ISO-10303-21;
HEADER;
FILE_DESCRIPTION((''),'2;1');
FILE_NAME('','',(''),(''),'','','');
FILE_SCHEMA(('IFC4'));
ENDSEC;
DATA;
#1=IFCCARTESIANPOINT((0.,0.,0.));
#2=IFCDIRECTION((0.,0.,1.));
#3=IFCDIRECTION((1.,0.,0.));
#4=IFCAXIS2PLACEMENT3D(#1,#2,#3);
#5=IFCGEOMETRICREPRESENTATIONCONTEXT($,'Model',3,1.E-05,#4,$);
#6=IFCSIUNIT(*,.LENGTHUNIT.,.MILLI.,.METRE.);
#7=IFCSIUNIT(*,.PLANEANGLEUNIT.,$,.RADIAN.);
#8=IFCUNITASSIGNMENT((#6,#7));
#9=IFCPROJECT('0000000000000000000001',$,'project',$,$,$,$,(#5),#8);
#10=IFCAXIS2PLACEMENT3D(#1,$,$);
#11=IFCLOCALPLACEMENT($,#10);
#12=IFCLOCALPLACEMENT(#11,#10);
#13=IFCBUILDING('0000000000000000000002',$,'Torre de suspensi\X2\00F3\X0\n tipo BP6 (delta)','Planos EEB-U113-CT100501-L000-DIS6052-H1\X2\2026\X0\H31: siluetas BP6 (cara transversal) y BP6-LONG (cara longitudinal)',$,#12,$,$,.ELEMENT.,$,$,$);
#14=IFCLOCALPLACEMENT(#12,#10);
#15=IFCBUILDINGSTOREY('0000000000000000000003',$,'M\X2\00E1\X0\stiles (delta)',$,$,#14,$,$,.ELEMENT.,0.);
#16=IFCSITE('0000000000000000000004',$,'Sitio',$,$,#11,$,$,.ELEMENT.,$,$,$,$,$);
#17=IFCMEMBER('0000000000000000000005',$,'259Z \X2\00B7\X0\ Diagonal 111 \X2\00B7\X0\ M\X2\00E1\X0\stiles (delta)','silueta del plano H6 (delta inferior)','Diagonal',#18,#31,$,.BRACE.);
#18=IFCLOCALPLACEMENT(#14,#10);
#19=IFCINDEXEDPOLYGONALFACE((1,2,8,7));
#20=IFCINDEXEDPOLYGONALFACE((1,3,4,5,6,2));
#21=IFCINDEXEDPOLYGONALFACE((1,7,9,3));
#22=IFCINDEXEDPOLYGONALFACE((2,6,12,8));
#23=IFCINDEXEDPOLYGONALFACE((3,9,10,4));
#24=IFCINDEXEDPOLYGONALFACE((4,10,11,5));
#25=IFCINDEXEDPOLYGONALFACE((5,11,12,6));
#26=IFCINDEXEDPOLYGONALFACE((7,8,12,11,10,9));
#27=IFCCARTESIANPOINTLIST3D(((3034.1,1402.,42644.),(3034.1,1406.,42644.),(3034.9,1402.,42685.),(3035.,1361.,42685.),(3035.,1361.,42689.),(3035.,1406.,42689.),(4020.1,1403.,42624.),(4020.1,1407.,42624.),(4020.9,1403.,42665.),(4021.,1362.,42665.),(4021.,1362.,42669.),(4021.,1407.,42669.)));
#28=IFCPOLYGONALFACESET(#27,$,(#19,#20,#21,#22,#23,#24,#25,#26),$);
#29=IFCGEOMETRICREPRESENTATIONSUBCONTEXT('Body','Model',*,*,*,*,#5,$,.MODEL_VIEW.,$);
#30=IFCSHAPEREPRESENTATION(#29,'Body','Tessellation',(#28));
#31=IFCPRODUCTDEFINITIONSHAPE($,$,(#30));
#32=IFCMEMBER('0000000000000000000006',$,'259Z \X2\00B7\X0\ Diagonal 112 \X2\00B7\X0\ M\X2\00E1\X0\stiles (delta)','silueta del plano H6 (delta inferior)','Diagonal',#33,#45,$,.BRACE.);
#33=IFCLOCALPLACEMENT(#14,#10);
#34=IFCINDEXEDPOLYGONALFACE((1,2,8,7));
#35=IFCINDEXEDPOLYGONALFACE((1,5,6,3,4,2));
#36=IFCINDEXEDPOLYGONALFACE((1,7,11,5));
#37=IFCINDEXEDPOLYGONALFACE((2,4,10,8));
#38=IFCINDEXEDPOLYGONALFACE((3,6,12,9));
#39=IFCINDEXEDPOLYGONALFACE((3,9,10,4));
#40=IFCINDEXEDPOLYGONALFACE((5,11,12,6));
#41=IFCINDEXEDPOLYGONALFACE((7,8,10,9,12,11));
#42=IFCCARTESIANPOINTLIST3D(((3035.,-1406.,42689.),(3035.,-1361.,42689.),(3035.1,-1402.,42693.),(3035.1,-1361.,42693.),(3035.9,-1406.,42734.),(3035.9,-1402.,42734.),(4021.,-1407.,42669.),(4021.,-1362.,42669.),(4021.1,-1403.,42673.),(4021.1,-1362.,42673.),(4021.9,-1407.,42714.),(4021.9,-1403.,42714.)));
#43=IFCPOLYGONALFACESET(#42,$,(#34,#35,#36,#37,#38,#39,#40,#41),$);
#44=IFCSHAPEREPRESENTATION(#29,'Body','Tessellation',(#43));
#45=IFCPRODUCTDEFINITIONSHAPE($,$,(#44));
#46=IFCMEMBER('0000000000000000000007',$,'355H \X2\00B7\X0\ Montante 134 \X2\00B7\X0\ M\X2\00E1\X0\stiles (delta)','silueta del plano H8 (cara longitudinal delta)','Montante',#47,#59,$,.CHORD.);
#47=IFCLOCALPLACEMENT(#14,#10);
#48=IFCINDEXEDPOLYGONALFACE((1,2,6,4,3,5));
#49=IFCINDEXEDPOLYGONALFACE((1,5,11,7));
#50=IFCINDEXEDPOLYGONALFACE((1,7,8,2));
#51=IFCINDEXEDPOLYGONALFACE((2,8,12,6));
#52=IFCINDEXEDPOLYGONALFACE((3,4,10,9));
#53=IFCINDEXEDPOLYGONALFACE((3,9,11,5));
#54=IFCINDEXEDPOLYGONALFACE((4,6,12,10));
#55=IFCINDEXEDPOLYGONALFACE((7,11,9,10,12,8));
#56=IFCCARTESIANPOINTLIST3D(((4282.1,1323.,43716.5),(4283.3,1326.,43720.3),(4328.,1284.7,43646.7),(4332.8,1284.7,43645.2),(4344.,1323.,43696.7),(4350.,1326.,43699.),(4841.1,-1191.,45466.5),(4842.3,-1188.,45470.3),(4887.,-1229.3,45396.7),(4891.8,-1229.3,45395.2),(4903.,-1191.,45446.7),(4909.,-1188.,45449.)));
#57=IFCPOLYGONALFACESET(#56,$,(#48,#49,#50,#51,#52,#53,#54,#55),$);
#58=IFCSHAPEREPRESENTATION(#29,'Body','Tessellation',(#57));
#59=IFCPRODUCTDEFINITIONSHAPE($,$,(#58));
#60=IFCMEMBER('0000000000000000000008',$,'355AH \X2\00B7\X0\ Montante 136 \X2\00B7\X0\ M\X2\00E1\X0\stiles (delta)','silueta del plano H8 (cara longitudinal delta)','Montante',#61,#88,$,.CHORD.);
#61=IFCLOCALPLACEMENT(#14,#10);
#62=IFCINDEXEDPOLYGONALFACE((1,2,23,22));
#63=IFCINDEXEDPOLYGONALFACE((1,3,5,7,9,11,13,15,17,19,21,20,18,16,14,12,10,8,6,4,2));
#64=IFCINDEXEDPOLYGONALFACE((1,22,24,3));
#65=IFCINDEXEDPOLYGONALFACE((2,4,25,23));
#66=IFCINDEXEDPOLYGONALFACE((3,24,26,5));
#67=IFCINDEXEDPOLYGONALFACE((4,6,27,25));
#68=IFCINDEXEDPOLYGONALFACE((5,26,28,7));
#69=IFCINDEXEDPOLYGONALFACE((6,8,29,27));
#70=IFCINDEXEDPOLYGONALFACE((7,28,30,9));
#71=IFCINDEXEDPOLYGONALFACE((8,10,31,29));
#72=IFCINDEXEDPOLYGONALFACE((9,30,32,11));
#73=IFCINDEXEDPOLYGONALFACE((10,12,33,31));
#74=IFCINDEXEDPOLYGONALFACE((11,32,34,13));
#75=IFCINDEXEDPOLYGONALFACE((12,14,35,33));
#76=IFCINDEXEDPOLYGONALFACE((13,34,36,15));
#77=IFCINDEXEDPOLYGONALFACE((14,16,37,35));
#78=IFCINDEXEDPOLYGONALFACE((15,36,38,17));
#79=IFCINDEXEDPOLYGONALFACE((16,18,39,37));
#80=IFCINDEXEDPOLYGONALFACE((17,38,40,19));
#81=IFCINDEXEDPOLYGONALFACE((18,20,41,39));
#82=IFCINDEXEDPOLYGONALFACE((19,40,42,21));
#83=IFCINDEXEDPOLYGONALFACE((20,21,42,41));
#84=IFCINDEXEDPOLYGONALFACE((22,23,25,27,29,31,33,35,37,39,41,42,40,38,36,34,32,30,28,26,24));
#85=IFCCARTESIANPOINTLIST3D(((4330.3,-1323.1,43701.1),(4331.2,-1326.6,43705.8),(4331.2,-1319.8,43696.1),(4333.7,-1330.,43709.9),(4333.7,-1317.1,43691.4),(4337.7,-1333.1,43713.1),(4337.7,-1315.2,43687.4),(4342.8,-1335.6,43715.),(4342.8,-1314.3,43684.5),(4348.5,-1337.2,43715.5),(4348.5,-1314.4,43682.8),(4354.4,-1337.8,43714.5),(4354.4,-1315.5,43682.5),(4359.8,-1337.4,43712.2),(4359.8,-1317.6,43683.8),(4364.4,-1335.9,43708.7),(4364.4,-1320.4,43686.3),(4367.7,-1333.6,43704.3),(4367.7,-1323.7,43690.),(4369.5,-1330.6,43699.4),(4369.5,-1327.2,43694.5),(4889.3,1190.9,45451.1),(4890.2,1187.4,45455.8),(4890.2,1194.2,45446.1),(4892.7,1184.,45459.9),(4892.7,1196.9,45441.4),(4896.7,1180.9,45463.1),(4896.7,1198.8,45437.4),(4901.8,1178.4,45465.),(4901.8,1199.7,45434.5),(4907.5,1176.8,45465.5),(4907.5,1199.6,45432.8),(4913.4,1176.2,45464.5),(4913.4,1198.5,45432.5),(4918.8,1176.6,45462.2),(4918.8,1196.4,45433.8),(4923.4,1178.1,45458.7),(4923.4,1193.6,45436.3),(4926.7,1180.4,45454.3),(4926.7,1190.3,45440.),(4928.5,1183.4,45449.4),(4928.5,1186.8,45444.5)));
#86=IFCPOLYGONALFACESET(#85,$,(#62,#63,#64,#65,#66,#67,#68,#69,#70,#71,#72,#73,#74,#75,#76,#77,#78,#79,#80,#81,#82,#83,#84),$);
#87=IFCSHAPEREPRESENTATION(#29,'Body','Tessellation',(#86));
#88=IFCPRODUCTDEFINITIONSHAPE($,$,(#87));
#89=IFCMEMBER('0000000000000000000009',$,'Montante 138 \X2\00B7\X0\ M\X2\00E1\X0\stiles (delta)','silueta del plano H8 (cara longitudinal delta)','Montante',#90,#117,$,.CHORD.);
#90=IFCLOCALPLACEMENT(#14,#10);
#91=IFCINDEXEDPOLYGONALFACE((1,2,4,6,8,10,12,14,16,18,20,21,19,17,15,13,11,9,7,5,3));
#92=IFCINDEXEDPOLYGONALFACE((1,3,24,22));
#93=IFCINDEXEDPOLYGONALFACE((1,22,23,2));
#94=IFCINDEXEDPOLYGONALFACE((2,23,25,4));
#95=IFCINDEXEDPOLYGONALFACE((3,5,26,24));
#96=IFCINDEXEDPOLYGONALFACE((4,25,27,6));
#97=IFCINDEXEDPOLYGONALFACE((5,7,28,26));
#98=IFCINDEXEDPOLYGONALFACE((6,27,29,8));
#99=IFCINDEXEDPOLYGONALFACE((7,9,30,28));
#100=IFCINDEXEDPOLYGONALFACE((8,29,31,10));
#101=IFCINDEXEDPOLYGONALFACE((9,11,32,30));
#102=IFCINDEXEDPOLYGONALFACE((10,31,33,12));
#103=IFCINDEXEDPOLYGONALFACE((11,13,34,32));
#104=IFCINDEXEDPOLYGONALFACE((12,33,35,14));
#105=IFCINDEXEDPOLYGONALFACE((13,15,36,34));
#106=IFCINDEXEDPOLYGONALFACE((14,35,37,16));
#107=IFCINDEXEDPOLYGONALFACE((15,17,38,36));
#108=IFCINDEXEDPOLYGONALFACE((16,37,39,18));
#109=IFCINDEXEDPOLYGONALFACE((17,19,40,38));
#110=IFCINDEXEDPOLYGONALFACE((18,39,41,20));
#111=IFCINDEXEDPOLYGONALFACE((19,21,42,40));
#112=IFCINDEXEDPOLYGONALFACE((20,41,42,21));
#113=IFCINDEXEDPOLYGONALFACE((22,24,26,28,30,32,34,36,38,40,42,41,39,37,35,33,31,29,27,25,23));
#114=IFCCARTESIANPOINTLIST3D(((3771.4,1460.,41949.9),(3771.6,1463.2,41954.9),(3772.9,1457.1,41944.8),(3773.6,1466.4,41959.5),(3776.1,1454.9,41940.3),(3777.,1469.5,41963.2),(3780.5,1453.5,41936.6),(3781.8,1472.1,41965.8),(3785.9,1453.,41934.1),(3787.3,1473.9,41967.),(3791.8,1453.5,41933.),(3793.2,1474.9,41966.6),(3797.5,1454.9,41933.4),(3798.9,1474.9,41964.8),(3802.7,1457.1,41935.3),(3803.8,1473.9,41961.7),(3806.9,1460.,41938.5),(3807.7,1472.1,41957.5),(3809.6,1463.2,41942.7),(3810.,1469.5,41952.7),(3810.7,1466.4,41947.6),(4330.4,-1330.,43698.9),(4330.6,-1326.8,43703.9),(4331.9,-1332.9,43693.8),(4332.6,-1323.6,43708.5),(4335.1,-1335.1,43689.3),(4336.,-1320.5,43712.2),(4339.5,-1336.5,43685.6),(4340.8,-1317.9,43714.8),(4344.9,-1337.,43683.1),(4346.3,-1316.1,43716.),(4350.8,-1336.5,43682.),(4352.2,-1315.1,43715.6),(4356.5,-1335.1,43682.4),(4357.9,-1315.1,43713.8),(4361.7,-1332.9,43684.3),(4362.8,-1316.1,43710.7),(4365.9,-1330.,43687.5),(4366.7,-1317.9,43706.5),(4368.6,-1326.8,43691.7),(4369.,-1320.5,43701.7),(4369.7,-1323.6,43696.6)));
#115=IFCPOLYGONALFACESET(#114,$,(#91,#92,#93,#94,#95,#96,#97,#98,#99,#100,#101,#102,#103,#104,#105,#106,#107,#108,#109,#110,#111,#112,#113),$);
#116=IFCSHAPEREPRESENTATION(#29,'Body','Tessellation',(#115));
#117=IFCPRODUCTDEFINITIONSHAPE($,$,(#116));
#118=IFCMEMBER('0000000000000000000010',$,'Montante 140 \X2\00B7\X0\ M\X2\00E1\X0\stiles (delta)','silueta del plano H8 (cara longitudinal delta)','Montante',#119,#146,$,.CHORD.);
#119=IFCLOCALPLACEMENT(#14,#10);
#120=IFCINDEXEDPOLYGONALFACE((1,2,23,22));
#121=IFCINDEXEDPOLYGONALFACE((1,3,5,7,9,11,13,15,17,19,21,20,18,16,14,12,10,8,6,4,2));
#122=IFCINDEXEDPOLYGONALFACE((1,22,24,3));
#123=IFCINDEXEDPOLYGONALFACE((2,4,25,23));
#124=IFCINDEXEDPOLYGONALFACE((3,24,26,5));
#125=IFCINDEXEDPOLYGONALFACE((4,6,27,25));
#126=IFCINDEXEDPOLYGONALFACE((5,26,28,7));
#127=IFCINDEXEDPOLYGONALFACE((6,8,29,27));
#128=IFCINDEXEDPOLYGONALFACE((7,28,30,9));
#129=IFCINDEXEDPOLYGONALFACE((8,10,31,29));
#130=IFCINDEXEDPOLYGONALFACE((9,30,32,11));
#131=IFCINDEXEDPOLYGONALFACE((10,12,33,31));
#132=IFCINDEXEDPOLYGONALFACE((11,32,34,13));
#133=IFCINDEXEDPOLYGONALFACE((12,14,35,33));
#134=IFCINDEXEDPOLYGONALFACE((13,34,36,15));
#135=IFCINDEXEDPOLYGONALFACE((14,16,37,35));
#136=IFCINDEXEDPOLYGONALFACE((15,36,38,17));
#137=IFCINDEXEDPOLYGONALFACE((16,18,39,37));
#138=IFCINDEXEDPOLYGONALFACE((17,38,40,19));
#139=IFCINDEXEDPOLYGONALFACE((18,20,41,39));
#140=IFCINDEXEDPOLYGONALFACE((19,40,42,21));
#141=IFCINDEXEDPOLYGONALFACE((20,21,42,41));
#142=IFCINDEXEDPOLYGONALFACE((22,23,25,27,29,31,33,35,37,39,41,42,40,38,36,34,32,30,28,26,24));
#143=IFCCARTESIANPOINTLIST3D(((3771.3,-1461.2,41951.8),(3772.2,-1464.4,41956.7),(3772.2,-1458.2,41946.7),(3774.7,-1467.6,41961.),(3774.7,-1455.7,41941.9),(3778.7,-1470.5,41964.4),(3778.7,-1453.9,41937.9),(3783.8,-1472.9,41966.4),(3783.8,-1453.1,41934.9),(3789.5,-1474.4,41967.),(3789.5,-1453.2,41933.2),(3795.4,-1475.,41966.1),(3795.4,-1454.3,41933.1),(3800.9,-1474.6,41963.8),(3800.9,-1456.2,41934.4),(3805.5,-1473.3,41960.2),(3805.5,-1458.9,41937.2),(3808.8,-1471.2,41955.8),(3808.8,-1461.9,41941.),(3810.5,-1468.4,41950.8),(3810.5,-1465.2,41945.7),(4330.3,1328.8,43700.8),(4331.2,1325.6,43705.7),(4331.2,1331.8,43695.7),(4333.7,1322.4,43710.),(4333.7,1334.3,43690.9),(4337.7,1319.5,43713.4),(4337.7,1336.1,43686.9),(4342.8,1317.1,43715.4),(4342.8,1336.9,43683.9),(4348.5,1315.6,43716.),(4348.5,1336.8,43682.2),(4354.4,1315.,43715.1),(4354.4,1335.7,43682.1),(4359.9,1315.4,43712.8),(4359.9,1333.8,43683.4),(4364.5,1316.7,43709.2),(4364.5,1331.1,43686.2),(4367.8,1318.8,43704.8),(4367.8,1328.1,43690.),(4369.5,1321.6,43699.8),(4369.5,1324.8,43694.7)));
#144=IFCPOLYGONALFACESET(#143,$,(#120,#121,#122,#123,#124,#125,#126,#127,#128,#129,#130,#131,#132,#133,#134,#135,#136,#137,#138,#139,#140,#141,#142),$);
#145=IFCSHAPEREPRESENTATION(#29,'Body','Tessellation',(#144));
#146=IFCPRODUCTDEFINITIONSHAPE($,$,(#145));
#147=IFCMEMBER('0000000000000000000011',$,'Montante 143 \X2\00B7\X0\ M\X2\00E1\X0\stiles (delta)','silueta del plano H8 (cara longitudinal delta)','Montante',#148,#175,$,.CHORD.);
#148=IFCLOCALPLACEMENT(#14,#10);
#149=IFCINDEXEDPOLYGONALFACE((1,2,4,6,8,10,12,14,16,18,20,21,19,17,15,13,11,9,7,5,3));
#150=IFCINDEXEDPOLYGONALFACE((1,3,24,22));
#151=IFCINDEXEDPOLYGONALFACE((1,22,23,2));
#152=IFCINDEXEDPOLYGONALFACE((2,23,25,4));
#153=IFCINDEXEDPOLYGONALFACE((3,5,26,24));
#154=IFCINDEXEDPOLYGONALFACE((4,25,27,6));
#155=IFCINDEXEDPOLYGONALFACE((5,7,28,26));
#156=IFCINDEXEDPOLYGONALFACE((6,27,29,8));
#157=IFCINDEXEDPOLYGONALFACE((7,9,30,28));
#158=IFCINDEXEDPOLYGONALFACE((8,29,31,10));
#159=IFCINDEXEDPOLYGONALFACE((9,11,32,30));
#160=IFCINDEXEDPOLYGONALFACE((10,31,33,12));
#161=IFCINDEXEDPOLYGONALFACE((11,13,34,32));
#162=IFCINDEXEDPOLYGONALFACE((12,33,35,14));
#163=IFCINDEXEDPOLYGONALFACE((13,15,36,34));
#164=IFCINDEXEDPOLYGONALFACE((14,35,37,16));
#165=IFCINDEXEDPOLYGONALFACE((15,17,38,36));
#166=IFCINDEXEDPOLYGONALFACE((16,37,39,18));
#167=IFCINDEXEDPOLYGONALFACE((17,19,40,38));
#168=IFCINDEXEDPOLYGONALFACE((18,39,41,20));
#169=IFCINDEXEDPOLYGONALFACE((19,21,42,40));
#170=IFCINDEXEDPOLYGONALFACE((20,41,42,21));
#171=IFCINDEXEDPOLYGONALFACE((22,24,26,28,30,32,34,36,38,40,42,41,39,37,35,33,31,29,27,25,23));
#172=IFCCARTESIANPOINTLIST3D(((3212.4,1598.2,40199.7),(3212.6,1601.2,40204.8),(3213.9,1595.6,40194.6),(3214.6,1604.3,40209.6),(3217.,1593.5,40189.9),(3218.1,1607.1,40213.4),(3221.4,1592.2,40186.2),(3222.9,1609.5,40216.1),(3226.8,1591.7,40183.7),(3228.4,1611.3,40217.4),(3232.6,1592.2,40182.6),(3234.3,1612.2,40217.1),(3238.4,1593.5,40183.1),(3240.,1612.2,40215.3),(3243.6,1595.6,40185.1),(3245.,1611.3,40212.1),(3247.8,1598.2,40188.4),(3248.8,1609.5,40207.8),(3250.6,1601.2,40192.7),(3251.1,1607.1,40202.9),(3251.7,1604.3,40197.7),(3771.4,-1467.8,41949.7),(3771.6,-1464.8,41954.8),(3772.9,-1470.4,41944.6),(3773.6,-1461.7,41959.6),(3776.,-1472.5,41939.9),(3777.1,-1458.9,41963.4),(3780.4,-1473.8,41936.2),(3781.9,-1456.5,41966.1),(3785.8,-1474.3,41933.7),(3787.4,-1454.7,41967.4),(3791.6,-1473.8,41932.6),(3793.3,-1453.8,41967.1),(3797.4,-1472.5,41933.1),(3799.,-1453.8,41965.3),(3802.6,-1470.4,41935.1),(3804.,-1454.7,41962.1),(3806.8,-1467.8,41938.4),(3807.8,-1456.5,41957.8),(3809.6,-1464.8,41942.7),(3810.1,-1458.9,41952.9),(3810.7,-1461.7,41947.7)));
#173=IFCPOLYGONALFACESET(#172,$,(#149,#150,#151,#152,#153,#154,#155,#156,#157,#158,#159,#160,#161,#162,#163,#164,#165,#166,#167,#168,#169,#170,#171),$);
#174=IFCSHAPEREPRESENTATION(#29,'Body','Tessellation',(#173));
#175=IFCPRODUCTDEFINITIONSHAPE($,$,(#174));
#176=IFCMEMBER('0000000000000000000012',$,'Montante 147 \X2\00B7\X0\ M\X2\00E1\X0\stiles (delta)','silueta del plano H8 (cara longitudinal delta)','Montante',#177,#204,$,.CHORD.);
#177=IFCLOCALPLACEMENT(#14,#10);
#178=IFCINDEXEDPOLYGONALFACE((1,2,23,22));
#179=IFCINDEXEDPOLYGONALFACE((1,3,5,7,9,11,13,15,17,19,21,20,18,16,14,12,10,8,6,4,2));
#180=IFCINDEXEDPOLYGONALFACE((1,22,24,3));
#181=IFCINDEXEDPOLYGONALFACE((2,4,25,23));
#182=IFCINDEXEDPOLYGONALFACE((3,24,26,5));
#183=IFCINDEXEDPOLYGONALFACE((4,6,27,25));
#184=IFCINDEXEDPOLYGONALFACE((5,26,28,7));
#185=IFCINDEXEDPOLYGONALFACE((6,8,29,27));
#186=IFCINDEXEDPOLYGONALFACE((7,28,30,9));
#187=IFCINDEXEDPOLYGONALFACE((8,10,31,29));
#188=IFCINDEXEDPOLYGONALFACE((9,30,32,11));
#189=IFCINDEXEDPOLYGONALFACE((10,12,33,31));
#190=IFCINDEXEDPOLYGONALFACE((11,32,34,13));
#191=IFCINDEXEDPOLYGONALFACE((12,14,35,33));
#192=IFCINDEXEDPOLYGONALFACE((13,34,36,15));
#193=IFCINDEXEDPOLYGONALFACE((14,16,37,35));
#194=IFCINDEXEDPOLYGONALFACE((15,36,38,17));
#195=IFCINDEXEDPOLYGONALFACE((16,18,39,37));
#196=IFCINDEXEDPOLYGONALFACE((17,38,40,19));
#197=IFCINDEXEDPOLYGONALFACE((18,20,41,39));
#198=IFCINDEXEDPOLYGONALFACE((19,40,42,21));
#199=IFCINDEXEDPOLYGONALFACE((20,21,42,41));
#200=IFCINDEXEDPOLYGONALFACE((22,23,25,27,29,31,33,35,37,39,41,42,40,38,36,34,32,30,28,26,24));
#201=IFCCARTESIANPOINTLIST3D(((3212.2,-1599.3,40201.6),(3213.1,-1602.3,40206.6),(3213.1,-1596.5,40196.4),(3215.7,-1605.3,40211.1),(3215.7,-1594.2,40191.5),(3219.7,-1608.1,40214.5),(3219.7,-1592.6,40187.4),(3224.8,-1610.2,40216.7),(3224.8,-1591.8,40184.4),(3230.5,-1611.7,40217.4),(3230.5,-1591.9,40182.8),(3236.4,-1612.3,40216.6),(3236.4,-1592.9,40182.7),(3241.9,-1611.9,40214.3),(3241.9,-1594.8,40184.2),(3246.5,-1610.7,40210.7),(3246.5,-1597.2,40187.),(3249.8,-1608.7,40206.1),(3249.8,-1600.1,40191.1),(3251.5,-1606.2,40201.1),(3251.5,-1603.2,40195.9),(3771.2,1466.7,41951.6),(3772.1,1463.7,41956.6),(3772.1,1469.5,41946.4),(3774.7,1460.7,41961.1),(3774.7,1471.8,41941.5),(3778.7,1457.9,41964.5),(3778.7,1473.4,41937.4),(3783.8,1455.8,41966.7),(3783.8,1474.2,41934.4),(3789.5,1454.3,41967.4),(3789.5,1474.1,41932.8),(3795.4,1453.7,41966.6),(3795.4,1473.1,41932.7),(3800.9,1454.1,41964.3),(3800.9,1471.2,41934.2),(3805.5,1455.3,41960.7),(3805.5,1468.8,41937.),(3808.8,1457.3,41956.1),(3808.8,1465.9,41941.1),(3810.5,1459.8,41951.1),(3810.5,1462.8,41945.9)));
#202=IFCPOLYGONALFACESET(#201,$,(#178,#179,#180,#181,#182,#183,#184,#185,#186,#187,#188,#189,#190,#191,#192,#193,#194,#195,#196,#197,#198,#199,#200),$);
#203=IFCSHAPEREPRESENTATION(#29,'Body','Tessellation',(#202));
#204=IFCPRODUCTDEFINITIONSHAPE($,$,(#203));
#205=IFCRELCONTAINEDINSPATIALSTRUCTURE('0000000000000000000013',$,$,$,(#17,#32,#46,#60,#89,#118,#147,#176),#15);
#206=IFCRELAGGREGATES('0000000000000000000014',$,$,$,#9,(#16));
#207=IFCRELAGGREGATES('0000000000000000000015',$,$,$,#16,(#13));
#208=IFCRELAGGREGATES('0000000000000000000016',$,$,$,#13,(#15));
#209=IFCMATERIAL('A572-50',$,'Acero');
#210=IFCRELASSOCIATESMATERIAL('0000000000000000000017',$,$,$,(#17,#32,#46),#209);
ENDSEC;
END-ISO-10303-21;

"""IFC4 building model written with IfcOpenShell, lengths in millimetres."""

from ifc_helpers import new_model, si_unit, frame, frame_2d, origin, origin_with_axes, place, context, subcontext, project, spatial, circle, l_section, extrude, material, element, save


model = new_model("IFC4")

# Units and contexts
model_context = context("Model", 3, precision=1e-05, world=origin_with_axes())
body_context = subcontext(model_context, "Body", "Model", "MODEL_VIEW")
ifc_project = project(units=[si_unit("LENGTHUNIT", "METRE", prefix="MILLI"), si_unit("PLANEANGLEUNIT", "RADIAN")], contexts=[model_context])

# Site, building, storey
site_placement = place(None, origin())
site = spatial("IfcSite", under=ifc_project, at=site_placement, Name="Sitio", CompositionType="ELEMENT")
building_placement = place(site_placement, origin())
building = spatial("IfcBuilding", under=site, at=building_placement, Name="Torre de suspensión tipo BP6 (delta)", Description="Planos EEB-U113-CT100501-L000-DIS6052-H1…H31: siluetas BP6 (cara transversal) y BP6-LONG (cara longitudinal)", CompositionType="ELEMENT")
storey_placement = place(building_placement, origin())
storey = spatial("IfcBuildingStorey", under=building, at=storey_placement, Name="Mástiles (delta)", CompositionType="ELEMENT", Elevation=0.0)

# Members
ifc_material = material(Name="A572-50", Category="Acero")
for number, where, z_axis, x_axis, name in (
    (1, (3035.0, 1406.0, 42689.0), (0.999794, 0.001014, -0.02028), (0.001014, -0.999999, -0.000021), "259Z · Diagonal 111 · Mástiles (delta)"),
    (2, (3035.0, -1406.0, 42689.0), (0.999794, -0.001014, -0.02028), (0.001014, 0.999999, -0.000021), "259Z · Diagonal 112 · Mástiles (delta)"),
):
    element("IfcMember", number, at=place(storey_placement, frame(where, z_axis=z_axis, x_axis=x_axis)), inside=storey, material=ifc_material, Name=name, Description="silueta del plano H6 (delta inferior)", ObjectType="Diagonal", PredefinedType="BRACE", context=body_context, shape_type="SweptSolid", body=[
        extrude(l_section(Depth=45.0, Width=45.0, Thickness=4.0, at=frame_2d((22.5, 22.5))), None, (0.0, 0.0, 1.0), 986.2),
    ])
member_1_placement = place(storey_placement, frame((4909.0, -1188.0, 45449.0), z_axis=(-0.179529, 0.807398, -0.562031), x_axis=(-0.245676, -0.590008, -0.769112)))
element("IfcMember", 3, at=member_1_placement, inside=storey, material=ifc_material, Name="355H · Montante 134 · Mástiles (delta)", Description="silueta del plano H8 (cara longitudinal delta)", ObjectType="Montante", PredefinedType="CHORD", context=body_context, shape_type="SweptSolid", body=[
    extrude(l_section(Depth=70.0, Width=70.0, Thickness=5.0, at=frame_2d((35.0, 35.0))), None, (0.0, 0.0, 1.0), 3113.7),
])
member_2_placement = place(storey_placement, frame((4909.0, 1188.0, 45449.0), z_axis=(-0.179529, -0.807398, -0.562031), x_axis=(-0.983753, 0.147345, 0.102567)))
element("IfcMember", 4, at=member_2_placement, inside=storey, Name="355AH · Montante 136 · Mástiles (delta)", Description="silueta del plano H8 (cara longitudinal delta)", ObjectType="Montante", PredefinedType="CHORD", context=body_context, shape_type="SweptSolid", body=[
    extrude(circle(Radius=20.0), None, (0.0, 0.0, 1.0), 3113.7),
])
for number, where, z_axis, x_axis, name in (
    (5, (4350.0, -1326.0, 43699.0), (-0.167365, 0.83533, -0.523653), (-0.254308, -0.549749, -0.795678), "Montante 138 · Mástiles (delta)"),
    (6, (4350.0, 1326.0, 43699.0), (-0.167365, -0.83533, -0.523653), (-0.985895, 0.141806, 0.088895), "Montante 140 · Mástiles (delta)"),
):
    element("IfcMember", number, at=place(storey_placement, frame(where, z_axis=z_axis, x_axis=x_axis)), inside=storey, Name=name, Description="silueta del plano H8 (cara longitudinal delta)", ObjectType="Montante", PredefinedType="CHORD", context=body_context, shape_type="SweptSolid", body=[
        extrude(circle(Radius=20.0), None, (0.0, 0.0, 1.0), 3340.0),
    ])
for number, where, z_axis, x_axis, name in (
    (7, (3791.0, -1464.0, 41950.0), (-0.156396, 0.8578, -0.489612), (-0.261013, -0.513984, -0.817125), "Montante 143 · Mástiles (delta)"),
    (8, (3791.0, 1464.0, 41950.0), (-0.156396, -0.8578, -0.489612), (-0.987694, 0.135828, 0.077527), "Montante 147 · Mástiles (delta)"),
):
    element("IfcMember", number, at=place(storey_placement, frame(where, z_axis=z_axis, x_axis=x_axis)), inside=storey, Name=name, Description="silueta del plano H8 (cara longitudinal delta)", ObjectType="Montante", PredefinedType="CHORD", context=body_context, shape_type="SweptSolid", body=[
        extrude(circle(Radius=20.0), None, (0.0, 0.0, 1.0), 3574.3),
    ])

save(model, "model.ifc")
